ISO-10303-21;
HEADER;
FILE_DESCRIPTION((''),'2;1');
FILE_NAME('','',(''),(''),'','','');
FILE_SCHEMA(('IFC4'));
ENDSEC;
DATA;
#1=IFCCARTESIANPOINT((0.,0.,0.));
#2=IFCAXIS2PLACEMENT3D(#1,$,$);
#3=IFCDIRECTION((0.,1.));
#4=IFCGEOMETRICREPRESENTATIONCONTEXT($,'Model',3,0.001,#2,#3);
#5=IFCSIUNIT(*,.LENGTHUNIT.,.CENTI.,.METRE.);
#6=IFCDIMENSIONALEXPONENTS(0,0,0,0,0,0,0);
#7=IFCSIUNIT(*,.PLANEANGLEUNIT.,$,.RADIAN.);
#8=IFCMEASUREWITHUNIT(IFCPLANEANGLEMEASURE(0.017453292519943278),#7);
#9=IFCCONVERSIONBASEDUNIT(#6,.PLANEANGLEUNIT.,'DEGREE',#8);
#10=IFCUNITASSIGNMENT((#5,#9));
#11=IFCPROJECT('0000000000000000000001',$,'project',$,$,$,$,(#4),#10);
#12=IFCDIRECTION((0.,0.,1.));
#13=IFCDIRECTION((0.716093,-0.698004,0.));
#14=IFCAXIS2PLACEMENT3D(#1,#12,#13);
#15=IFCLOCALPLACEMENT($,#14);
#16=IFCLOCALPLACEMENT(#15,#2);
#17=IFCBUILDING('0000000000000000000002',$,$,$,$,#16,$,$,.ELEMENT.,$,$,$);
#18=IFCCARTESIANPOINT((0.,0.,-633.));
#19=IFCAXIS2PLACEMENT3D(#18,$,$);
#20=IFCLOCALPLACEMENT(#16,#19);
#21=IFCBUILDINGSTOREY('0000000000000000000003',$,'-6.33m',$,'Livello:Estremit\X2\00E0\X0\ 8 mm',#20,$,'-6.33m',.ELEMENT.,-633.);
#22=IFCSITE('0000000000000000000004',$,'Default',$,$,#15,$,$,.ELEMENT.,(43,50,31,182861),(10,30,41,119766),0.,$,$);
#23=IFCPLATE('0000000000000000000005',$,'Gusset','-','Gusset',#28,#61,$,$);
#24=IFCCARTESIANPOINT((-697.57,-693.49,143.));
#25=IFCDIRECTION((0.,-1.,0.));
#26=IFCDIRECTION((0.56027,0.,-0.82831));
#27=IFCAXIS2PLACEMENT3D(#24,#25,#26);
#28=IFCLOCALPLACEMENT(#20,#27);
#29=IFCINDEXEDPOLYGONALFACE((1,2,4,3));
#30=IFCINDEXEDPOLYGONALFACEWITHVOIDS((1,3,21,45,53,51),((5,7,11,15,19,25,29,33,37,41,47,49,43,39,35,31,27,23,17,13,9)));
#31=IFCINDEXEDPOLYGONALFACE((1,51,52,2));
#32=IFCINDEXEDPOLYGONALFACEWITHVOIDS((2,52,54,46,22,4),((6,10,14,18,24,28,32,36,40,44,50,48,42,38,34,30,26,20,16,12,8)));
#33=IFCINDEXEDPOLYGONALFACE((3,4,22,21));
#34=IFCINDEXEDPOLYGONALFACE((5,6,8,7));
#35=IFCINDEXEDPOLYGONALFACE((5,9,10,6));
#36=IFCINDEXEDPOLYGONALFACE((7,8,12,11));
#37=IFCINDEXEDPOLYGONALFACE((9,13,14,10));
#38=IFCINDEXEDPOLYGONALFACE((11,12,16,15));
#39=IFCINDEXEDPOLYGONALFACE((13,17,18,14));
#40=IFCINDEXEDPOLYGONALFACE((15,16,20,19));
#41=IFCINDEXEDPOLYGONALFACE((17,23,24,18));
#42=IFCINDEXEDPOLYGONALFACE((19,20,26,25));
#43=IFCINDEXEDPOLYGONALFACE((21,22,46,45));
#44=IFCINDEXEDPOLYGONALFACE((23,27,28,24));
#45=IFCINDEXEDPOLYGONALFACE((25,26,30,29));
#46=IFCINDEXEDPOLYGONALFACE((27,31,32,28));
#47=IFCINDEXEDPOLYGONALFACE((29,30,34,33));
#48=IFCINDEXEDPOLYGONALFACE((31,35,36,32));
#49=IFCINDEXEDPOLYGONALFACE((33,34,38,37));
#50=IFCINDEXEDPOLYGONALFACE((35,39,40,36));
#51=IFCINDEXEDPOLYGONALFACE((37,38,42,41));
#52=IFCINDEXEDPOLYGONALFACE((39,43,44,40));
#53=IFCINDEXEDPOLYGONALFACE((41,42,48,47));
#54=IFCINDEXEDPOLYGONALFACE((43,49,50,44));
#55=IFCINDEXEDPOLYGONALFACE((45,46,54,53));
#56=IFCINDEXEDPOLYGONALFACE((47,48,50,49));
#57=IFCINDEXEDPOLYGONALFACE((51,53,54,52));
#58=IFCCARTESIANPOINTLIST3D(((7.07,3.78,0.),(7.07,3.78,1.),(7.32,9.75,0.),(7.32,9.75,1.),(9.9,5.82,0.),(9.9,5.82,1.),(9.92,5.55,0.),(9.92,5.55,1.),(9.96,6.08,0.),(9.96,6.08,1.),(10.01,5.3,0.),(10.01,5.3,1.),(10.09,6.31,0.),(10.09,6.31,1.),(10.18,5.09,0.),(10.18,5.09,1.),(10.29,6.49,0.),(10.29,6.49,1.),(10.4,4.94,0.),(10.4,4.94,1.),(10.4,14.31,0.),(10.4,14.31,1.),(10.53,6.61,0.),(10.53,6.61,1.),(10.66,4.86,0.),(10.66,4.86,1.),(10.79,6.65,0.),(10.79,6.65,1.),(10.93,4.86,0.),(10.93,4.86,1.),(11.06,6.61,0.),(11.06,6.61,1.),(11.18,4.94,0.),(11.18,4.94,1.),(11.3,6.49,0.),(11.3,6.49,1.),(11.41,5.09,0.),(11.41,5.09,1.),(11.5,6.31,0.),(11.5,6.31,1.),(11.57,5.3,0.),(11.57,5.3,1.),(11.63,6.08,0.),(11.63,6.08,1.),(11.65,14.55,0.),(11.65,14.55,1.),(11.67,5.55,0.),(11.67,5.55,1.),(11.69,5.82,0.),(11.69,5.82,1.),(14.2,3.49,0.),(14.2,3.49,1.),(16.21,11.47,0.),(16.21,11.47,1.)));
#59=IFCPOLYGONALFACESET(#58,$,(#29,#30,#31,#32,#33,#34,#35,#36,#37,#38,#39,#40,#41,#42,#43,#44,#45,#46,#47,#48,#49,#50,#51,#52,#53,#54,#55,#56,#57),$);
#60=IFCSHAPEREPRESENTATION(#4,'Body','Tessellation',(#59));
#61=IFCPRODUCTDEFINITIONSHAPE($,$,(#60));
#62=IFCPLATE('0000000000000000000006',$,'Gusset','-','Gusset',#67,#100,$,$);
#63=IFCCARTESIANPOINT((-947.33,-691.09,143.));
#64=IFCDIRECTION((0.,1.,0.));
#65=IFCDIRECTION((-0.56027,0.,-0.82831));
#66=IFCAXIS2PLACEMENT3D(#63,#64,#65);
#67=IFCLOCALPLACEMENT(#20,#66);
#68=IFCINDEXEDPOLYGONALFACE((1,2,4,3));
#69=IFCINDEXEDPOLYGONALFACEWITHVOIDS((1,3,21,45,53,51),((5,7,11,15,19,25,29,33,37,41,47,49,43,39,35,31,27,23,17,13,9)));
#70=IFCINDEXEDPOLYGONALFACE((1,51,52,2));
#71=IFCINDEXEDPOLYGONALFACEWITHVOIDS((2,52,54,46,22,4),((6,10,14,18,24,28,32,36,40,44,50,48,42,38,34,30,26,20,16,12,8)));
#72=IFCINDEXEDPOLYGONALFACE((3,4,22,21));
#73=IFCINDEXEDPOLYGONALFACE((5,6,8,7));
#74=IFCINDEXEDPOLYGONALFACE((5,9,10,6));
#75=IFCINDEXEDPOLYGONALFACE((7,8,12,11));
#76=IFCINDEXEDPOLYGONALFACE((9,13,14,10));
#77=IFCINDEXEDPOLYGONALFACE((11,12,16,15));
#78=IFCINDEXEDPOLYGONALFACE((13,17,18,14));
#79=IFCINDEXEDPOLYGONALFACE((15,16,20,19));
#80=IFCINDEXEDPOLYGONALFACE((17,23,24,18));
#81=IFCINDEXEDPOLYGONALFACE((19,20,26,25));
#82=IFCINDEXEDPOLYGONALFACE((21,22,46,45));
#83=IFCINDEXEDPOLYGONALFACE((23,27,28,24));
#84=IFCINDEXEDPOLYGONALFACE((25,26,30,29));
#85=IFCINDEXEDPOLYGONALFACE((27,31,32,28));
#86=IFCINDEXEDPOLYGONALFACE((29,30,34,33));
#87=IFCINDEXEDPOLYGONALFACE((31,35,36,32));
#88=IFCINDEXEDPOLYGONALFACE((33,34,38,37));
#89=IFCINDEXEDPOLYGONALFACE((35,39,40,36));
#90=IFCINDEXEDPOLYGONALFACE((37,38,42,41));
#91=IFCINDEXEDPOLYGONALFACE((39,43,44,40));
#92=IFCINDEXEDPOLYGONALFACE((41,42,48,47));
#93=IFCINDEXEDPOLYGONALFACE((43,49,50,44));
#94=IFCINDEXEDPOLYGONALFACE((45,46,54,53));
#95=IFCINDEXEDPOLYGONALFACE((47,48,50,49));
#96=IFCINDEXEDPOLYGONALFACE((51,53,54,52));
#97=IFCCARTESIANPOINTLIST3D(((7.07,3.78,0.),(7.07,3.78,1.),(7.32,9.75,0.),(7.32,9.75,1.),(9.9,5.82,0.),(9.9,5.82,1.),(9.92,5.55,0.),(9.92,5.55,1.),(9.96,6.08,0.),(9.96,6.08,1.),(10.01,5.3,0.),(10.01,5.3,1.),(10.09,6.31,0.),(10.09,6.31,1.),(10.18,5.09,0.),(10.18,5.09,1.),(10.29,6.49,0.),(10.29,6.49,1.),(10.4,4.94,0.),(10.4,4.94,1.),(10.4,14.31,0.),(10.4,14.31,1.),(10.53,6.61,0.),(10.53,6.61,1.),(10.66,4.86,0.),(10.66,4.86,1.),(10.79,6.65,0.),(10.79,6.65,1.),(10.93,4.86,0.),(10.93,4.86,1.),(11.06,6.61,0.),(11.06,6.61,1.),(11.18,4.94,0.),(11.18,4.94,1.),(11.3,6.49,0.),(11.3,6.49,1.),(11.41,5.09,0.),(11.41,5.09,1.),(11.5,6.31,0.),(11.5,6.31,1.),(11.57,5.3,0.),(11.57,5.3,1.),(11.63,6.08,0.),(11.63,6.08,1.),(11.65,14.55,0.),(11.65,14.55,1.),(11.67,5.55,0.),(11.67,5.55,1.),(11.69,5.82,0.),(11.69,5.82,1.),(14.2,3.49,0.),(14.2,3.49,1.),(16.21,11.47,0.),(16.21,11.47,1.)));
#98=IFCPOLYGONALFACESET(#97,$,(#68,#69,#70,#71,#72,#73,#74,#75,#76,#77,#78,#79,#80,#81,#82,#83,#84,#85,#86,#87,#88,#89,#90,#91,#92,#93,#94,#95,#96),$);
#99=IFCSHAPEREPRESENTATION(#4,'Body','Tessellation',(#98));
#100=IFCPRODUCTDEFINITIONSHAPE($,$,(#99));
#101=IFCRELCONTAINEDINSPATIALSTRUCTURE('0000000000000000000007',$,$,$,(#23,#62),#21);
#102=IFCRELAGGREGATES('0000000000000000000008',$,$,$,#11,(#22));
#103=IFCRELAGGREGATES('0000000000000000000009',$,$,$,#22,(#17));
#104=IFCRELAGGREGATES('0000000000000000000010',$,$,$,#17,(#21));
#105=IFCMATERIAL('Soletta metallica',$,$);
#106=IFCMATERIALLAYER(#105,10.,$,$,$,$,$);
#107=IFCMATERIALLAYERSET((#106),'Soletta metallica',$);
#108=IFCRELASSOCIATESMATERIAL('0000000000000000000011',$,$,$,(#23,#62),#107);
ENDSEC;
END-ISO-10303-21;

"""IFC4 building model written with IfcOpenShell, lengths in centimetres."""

from ifc_helpers import new_model, entity, si_unit, converted_unit, point, direction, frame, frame_2d, origin, origin_with_axes, origin_2d_with_axis, place, context, project, spatial, polyline, circle_curve, line_curve, trimmed, segment, composite_curve, circle, outline, extrude, material, layer, layer_set, element, save


model = new_model("IFC4")

# Units and contexts
model_context = context("Model", 3, precision=0.001, world=origin(), true_north=direction((0.0, 1.0)))
ifc_project = project(units=[si_unit("LENGTHUNIT", "METRE", prefix="CENTI"), converted_unit("PLANEANGLEUNIT", "DEGREE", entity("IfcPlaneAngleMeasure", 0.017453292519943278), si_unit("PLANEANGLEUNIT", "RADIAN"), dimensions=[0, 0, 0, 0, 0, 0, 0])], contexts=[model_context])

# Site, building, storey
site_placement = place(None, frame((0.0, 0.0, 0.0), z_axis=(0.0, 0.0, 1.0), x_axis=(0.716093, -0.698004, 0.0)))
site = spatial("IfcSite", under=ifc_project, at=site_placement, Name="Default", CompositionType="ELEMENT", RefLatitude=(43, 50, 31, 182861), RefLongitude=(10, 30, 41, 119766), RefElevation=0.0)
building_placement = place(site_placement, origin())
building = spatial("IfcBuilding", under=site, at=building_placement, CompositionType="ELEMENT")
storey_placement = place(building_placement, frame((0.0, 0.0, -633.0)))
storey = spatial("IfcBuildingStorey", under=building, at=storey_placement, Name="-6.33m", ObjectType="Livello:Estremità 8 mm", LongName="-6.33m", CompositionType="ELEMENT", Elevation=-633.0)

# Plates, openings
ifc_material = material(Name="Soletta metallica")
ifc_layer = layer(ifc_material, 10.0)
ifc_layer_set = layer_set([ifc_layer], Name="Soletta metallica")
plate_1_placement = place(storey_placement, frame((-697.57, -693.49, 143.0), z_axis=(0.0, -1.0, 0.0), x_axis=(0.56027, 0.0, -0.82831)))
plate_1 = element("IfcPlate", 1, at=plate_1_placement, inside=storey, material=ifc_layer_set, Name="Gusset", Description="-", ObjectType="Gusset", context=model_context, shape_type="SweptSolid", body=[
    extrude(outline(polyline([(10.91, 15.05), (7.32, 9.75), (7.07, 3.78), (14.2, 3.49), (16.21, 11.47), (10.91, 15.05)])), origin_with_axes(), (0.0, 0.0, 1.0), 1.0),
])
opening_1_placement = place(plate_1_placement, frame((0.0, 0.0, 0.0), z_axis=(0.0, 0.0, 1.0), x_axis=(1.0, 0.0, 0.0)))
element("IfcOpeningElement", 2, at=opening_1_placement, cuts=plate_1, ObjectType="Opening", context=model_context, shape_type="SweptSolid", body=[
    extrude(outline(composite_curve([segment(trimmed(line_curve((10.91, 15.05), (-0.56027, -0.82831), 0.9), [point((10.91, 15.05))], [point((10.4, 14.31))], True, "CARTESIAN"), True, "CONTINUOUS"), segment(trimmed(circle_curve(frame_2d((11.15, 13.8), x_axis=(-1.0, 0.0)), 0.9), [point((10.4, 14.31))], [point((11.65, 14.55))], False, "CARTESIAN"), True, "CONTINUOUS"), segment(trimmed(line_curve((11.65, 14.55), (-0.82831, 0.56027), 0.9), [point((11.65, 14.55))], [point((10.91, 15.05))], True, "CARTESIAN"), True, "CONTINUOUS")], self_intersect="UNKNOWN")), origin(), (0.0, 0.0, 1.0), 1.0),
])
opening_2_placement = place(plate_1_placement, frame((10.79, 5.75, -0.05), z_axis=(0.0, 0.0, 1.0), x_axis=(0.0, 1.0, 0.0)))
element("IfcOpeningElement", 3, at=opening_2_placement, cuts=plate_1, ObjectType="Opening", context=model_context, shape_type="SweptSolid", body=[
    extrude(circle(Radius=0.9, at=origin_2d_with_axis()), origin(), (0.0, 0.0, 1.0), 1.1),
])
plate_2_placement = place(storey_placement, frame((-947.33, -691.09, 143.0), z_axis=(0.0, 1.0, 0.0), x_axis=(-0.56027, 0.0, -0.82831)))
plate_2 = element("IfcPlate", 4, at=plate_2_placement, inside=storey, material=ifc_layer_set, Name="Gusset", Description="-", ObjectType="Gusset", context=model_context, shape_type="SweptSolid", body=[
    extrude(outline(polyline([(10.91, 15.05), (7.32, 9.75), (7.07, 3.78), (14.2, 3.49), (16.21, 11.47), (10.91, 15.05)])), origin_with_axes(), (0.0, 0.0, 1.0), 1.0),
])
opening_3_placement = place(plate_2_placement, frame((0.0, 0.0, 0.0), z_axis=(0.0, 0.0, 1.0), x_axis=(1.0, 0.0, 0.0)))
element("IfcOpeningElement", 5, at=opening_3_placement, cuts=plate_2, ObjectType="Opening", context=model_context, shape_type="SweptSolid", body=[
    extrude(outline(composite_curve([segment(trimmed(line_curve((10.91, 15.05), (-0.56027, -0.82831), 0.9), [point((10.91, 15.05))], [point((10.4, 14.31))], True, "CARTESIAN"), True, "CONTINUOUS"), segment(trimmed(circle_curve(frame_2d((11.15, 13.8), x_axis=(-1.0, 0.0)), 0.9), [point((10.4, 14.31))], [point((11.65, 14.55))], False, "CARTESIAN"), True, "CONTINUOUS"), segment(trimmed(line_curve((11.65, 14.55), (-0.82831, 0.56027), 0.9), [point((11.65, 14.55))], [point((10.91, 15.05))], True, "CARTESIAN"), True, "CONTINUOUS")], self_intersect="UNKNOWN")), origin(), (0.0, 0.0, 1.0), 1.0),
])
opening_4_placement = place(plate_2_placement, frame((10.79, 5.75, -0.05), z_axis=(0.0, 0.0, 1.0), x_axis=(0.0, 1.0, 0.0)))
element("IfcOpeningElement", 6, at=opening_4_placement, cuts=plate_2, ObjectType="Opening", context=model_context, shape_type="SweptSolid", body=[
    extrude(circle(Radius=0.9, at=origin_2d_with_axis()), origin(), (0.0, 0.0, 1.0), 1.1),
])

save(model, "model.ifc")
